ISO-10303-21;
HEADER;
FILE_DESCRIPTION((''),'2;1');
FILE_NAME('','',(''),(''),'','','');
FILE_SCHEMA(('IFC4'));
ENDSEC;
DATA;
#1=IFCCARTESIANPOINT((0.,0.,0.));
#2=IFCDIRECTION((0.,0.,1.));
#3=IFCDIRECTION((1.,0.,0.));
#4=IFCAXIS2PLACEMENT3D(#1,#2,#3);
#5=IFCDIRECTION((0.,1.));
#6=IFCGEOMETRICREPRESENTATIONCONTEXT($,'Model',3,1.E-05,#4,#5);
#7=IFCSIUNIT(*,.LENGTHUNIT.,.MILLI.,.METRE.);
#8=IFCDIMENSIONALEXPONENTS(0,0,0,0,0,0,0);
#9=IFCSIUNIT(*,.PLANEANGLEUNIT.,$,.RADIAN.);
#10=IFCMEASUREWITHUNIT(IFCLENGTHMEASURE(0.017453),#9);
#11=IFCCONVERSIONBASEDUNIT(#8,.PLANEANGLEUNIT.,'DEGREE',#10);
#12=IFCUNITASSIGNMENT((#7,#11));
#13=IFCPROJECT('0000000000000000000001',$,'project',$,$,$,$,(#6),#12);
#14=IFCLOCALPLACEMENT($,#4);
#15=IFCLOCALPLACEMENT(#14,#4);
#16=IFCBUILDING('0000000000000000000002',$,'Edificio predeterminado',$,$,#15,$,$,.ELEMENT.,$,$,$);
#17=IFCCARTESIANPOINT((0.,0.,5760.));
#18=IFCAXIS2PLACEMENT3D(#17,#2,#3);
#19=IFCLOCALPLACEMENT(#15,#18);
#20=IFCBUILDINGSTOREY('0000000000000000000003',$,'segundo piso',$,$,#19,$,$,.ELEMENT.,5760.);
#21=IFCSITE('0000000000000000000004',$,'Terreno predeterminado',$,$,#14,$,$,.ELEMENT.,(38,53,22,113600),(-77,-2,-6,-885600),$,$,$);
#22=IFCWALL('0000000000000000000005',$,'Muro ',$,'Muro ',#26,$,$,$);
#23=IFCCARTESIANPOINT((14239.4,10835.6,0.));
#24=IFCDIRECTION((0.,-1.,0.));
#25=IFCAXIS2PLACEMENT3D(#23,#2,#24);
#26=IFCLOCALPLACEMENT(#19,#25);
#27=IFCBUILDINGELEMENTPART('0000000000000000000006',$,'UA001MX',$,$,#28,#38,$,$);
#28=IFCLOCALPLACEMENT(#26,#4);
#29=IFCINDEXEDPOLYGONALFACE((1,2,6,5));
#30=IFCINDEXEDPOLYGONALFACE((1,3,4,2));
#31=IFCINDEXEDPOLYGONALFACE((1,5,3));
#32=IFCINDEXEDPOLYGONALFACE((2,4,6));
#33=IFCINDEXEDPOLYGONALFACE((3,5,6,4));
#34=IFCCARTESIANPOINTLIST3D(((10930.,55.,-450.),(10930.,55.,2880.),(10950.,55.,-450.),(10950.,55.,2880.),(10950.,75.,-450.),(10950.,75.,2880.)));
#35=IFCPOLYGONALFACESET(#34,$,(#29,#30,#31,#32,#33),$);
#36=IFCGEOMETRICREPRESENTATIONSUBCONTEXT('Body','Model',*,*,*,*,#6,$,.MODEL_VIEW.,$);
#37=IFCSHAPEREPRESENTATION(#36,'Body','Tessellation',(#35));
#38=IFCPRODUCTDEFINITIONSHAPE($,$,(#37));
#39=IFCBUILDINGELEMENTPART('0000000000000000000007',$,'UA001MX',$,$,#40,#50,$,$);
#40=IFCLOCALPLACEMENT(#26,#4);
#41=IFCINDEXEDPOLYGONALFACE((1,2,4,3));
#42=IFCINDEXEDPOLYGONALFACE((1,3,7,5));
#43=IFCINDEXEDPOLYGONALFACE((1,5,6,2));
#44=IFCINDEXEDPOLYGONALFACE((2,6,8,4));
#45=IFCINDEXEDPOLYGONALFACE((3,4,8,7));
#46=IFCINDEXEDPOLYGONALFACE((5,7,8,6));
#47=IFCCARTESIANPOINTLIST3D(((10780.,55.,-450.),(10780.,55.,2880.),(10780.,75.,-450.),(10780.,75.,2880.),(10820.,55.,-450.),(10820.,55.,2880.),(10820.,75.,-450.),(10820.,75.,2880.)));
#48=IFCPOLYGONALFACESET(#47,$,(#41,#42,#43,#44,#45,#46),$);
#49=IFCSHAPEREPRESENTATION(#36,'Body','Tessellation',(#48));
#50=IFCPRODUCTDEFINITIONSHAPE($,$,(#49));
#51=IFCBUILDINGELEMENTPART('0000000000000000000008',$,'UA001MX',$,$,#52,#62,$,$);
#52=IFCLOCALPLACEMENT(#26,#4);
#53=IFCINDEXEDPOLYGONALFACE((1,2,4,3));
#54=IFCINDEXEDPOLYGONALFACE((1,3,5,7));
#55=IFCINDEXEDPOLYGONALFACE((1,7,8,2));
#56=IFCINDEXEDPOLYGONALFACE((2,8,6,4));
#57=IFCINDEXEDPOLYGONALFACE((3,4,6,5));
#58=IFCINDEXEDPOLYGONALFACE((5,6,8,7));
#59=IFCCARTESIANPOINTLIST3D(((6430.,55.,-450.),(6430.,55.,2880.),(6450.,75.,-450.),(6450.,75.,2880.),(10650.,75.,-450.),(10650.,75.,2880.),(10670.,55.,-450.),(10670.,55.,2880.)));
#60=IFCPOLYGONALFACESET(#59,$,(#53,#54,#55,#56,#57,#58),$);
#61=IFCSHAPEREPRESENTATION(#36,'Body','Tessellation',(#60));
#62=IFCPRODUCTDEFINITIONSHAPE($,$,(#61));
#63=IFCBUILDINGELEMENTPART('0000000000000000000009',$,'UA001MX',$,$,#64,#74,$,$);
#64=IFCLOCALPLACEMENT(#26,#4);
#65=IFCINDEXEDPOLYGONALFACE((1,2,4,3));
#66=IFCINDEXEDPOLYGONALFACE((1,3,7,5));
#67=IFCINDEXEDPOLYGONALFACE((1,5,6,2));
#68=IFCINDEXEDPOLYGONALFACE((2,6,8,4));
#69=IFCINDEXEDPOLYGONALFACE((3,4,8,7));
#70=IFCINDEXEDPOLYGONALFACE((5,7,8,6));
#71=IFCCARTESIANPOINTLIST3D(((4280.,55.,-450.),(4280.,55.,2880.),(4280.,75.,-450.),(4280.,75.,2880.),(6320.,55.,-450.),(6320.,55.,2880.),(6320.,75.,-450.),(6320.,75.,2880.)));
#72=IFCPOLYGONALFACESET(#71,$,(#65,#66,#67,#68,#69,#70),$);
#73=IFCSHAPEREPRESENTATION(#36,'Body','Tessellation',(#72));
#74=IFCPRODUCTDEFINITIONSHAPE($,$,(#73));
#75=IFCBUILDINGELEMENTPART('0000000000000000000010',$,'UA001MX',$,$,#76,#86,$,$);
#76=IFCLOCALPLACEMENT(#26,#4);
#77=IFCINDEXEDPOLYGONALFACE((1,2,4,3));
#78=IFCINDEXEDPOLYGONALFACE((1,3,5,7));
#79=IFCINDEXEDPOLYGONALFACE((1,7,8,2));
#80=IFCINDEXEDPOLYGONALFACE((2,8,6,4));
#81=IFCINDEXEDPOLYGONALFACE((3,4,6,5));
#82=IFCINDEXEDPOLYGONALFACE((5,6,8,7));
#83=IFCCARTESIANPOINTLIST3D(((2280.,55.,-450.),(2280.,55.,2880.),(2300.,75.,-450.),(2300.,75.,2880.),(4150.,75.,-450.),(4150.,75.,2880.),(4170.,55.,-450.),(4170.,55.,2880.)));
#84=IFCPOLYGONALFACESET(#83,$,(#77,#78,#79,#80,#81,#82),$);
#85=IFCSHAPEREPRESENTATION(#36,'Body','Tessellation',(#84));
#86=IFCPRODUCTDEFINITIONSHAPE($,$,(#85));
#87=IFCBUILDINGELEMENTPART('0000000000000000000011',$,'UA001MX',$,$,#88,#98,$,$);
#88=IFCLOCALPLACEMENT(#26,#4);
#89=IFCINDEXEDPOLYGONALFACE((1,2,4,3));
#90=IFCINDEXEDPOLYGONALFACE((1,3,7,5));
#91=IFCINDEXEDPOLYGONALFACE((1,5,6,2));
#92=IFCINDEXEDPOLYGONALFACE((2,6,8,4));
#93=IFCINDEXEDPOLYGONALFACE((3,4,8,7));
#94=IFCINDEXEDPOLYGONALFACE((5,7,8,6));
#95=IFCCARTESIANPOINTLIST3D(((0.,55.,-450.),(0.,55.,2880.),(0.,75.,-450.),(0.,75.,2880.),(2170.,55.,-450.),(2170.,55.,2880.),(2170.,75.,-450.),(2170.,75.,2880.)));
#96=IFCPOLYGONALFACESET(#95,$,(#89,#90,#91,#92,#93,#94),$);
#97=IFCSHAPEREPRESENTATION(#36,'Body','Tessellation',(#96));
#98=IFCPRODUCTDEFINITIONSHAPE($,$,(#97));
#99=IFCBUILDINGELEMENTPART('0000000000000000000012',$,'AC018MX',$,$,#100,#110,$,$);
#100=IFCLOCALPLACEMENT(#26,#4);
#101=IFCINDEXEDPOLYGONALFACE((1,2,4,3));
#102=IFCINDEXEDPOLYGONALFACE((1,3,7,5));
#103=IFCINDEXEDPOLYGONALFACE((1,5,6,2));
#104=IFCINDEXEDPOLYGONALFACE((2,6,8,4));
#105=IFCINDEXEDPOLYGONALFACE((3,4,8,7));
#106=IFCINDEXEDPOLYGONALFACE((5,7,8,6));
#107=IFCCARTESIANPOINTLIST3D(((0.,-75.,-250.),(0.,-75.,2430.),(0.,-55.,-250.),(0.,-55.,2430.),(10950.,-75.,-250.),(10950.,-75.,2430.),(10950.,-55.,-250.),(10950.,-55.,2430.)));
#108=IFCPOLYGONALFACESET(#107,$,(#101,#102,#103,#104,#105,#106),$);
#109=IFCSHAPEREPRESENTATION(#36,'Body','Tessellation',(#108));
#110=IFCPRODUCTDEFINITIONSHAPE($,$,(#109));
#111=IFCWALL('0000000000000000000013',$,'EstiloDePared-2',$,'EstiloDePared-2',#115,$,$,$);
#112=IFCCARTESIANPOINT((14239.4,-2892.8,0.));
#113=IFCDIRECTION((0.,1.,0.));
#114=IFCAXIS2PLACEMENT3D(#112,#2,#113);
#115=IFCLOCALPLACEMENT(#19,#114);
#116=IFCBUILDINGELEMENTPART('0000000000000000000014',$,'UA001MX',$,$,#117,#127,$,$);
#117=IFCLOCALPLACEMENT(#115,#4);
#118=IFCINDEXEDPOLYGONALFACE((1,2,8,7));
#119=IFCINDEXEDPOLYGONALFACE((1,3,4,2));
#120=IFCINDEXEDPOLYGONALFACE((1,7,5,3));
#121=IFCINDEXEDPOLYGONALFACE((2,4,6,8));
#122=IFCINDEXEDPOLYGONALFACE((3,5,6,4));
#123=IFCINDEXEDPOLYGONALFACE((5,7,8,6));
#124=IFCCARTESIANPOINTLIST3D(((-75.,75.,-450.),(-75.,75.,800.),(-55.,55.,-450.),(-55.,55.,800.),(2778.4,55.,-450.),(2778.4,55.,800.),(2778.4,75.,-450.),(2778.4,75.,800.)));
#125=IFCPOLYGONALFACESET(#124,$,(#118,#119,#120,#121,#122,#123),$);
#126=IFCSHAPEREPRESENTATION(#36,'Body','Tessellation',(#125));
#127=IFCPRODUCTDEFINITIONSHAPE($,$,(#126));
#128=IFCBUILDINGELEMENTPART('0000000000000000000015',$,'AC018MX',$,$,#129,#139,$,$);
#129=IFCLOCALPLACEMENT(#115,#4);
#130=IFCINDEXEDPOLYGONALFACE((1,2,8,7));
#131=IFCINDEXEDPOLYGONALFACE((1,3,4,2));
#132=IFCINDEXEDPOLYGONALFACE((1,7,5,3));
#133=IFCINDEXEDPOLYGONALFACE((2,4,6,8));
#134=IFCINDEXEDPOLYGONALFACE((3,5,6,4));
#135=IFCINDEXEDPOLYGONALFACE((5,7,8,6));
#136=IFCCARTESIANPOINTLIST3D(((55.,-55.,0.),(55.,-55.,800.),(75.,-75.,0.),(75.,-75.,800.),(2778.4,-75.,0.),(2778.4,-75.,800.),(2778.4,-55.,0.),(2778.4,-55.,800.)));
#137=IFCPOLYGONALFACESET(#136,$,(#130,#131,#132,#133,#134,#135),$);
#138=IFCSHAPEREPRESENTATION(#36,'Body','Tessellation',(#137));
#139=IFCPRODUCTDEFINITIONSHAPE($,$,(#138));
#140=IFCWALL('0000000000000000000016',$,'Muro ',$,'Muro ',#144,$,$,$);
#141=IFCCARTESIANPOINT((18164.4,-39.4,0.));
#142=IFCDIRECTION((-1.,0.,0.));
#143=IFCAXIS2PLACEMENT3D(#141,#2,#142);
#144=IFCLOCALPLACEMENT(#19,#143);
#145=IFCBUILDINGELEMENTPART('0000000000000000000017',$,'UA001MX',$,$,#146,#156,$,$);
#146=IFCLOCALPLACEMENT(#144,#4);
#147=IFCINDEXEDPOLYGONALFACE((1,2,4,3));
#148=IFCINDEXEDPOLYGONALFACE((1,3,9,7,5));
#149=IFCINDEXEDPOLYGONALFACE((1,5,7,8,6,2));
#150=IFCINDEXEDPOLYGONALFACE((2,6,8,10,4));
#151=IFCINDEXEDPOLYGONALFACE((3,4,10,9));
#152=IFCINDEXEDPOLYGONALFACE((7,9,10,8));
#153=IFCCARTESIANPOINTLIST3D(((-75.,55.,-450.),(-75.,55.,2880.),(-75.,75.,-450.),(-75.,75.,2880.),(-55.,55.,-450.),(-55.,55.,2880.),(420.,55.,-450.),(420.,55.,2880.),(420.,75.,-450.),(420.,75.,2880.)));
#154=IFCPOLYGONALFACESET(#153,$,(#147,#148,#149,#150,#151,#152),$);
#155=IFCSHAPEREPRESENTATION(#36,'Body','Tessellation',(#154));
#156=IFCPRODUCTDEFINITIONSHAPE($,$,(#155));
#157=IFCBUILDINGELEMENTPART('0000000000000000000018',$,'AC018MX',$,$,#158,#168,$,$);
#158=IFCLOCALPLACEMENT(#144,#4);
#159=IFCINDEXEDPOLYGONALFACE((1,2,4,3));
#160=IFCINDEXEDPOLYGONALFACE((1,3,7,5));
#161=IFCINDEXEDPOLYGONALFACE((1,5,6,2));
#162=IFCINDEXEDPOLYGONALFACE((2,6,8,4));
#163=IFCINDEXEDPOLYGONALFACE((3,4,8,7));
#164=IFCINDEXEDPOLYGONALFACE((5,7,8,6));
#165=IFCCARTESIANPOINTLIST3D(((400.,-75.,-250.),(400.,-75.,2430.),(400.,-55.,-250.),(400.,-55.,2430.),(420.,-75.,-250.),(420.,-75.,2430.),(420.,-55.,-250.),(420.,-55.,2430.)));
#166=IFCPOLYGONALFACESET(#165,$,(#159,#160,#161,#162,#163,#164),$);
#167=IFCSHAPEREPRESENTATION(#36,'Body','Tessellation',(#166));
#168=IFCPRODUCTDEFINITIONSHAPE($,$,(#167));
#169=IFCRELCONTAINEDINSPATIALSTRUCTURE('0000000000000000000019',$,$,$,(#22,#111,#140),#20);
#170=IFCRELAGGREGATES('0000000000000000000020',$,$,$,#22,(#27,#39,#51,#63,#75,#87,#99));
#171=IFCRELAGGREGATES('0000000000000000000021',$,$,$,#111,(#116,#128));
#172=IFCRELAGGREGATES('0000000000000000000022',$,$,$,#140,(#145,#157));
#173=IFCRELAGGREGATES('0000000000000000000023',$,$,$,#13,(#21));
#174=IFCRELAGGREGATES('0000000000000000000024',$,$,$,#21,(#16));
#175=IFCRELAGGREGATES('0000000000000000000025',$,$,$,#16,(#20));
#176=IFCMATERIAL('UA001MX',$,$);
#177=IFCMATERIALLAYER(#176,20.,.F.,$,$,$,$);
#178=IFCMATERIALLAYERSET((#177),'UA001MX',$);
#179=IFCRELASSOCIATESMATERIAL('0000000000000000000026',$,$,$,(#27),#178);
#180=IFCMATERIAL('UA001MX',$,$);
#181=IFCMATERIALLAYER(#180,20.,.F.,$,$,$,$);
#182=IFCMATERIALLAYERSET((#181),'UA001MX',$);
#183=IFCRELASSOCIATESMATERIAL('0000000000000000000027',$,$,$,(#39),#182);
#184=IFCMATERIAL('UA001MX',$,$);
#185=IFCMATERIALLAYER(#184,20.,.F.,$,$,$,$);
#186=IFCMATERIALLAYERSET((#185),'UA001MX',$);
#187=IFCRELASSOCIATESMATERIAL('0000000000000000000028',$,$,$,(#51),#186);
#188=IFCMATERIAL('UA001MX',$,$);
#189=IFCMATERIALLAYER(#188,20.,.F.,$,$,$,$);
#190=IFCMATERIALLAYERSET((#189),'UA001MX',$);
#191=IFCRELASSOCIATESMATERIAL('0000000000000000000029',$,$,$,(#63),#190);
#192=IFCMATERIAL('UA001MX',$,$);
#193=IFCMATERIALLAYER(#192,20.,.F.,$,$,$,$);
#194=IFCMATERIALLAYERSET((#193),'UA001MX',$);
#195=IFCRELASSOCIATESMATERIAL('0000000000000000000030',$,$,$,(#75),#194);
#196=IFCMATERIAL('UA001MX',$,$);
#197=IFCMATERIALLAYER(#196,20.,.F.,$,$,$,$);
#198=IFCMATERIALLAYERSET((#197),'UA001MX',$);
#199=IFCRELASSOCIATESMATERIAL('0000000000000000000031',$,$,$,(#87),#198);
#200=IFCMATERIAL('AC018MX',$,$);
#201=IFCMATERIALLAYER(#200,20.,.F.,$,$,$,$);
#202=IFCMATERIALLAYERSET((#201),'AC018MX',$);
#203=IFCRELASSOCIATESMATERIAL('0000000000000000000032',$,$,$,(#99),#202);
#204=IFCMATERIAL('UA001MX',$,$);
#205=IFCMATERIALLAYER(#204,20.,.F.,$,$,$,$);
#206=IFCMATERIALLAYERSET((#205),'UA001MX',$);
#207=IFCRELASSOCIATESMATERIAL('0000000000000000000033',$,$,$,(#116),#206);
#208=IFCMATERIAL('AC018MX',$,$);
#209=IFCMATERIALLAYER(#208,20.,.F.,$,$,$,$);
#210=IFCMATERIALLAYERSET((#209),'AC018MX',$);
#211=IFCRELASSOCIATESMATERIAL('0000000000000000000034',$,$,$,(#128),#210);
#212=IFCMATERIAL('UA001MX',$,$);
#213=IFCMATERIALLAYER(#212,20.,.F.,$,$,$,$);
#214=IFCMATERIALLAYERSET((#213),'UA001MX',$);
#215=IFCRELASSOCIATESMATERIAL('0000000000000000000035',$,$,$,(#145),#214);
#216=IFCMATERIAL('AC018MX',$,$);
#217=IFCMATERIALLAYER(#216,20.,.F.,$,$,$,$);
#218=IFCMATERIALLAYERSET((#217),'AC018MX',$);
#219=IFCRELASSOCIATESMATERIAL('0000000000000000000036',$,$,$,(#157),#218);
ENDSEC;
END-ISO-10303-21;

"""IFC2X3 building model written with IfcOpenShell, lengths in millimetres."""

from ifc_helpers import new_model, entity, si_unit, converted_unit, direction, frame, origin_with_axes, place, context, subcontext, project, spatial, polyline, outline, extrude, material, layer, layer_set, layer_usage, element, aggregate, save


model = new_model("IFC2X3")

# Units and contexts
model_context = context("Model", 3, precision=1e-05, world=origin_with_axes(), true_north=direction((0.0, 1.0)))
body_context = subcontext(model_context, "Body", "Model", "MODEL_VIEW")
ifc_project = project(units=[si_unit("LENGTHUNIT", "METRE", prefix="MILLI"), converted_unit("PLANEANGLEUNIT", "DEGREE", entity("IfcLengthMeasure", 0.017453), si_unit("PLANEANGLEUNIT", "RADIAN"), dimensions=[0, 0, 0, 0, 0, 0, 0])], contexts=[model_context])

# Site, building, storey
site_placement = place(None, origin_with_axes())
site = spatial("IfcSite", under=ifc_project, at=site_placement, Name="Terreno predeterminado", CompositionType="ELEMENT", RefLatitude=(38, 53, 22, 113600), RefLongitude=(-77, -2, -6, -885600))
building_placement = place(site_placement, origin_with_axes())
building = spatial("IfcBuilding", under=site, at=building_placement, Name="Edificio predeterminado", CompositionType="ELEMENT")
storey_placement = place(building_placement, frame((0.0, 0.0, 5760.0), z_axis=(0.0, 0.0, 1.0), x_axis=(1.0, 0.0, 0.0)))
storey = spatial("IfcBuildingStorey", under=building, at=storey_placement, Name="segundo piso", CompositionType="ELEMENT", Elevation=5760.0)

# Walls, building element parts
wall_1_placement = place(storey_placement, frame((14239.4, 10835.6, 0.0), z_axis=(0.0, 0.0, 1.0), x_axis=(0.0, -1.0, 0.0)))
wall_1 = element("IfcWall", 1, at=wall_1_placement, inside=storey, Name="Muro ", ObjectType="Muro ")
ifc_material_1 = material(Name="UA001MX")
ifc_layer_1 = layer(ifc_material_1, 20.0, ventilated=False)
ifc_layer_set_1 = layer_set([ifc_layer_1], Name="UA001MX")
ifc_layer_usage_1 = layer_usage(ifc_layer_set_1, "AXIS2", "NEGATIVE", -75.0)
building_element_part_1_placement = place(wall_1_placement, origin_with_axes())
building_element_part_1 = element("IfcBuildingElementPart", 2, at=building_element_part_1_placement, material=ifc_layer_usage_1, Name="UA001MX", context=body_context, shape_type="SweptSolid", body=[
    extrude(outline(polyline([(10950.0, 75.0), (10950.0, 55.0), (10930.0, 55.0), (10950.0, 75.0)])), frame((0.0, 0.0, -450.0), z_axis=(0.0, 0.0, 1.0), x_axis=(1.0, 0.0, 0.0)), (0.0, 0.0, 1.0), 3330.0),
])
ifc_material_2 = material(Name="UA001MX")
ifc_layer_2 = layer(ifc_material_2, 20.0, ventilated=False)
ifc_layer_set_2 = layer_set([ifc_layer_2], Name="UA001MX")
ifc_layer_usage_2 = layer_usage(ifc_layer_set_2, "AXIS2", "NEGATIVE", -75.0)
building_element_part_2_placement = place(wall_1_placement, origin_with_axes())
building_element_part_2 = element("IfcBuildingElementPart", 3, at=building_element_part_2_placement, material=ifc_layer_usage_2, Name="UA001MX", context=body_context, shape_type="SweptSolid", body=[
    extrude(outline(polyline([(10820.0, 75.0), (10820.0, 55.0), (10780.0, 55.0), (10780.0, 75.0), (10820.0, 75.0)])), frame((0.0, 0.0, -450.0), z_axis=(0.0, 0.0, 1.0), x_axis=(1.0, 0.0, 0.0)), (0.0, 0.0, 1.0), 3330.0),
])
ifc_material_3 = material(Name="UA001MX")
ifc_layer_3 = layer(ifc_material_3, 20.0, ventilated=False)
ifc_layer_set_3 = layer_set([ifc_layer_3], Name="UA001MX")
ifc_layer_usage_3 = layer_usage(ifc_layer_set_3, "AXIS2", "NEGATIVE", -75.0)
building_element_part_3_placement = place(wall_1_placement, origin_with_axes())
building_element_part_3 = element("IfcBuildingElementPart", 4, at=building_element_part_3_placement, material=ifc_layer_usage_3, Name="UA001MX", context=body_context, shape_type="SweptSolid", body=[
    extrude(outline(polyline([(10650.0, 75.0), (10670.0, 55.0), (6430.0, 55.0), (6450.0, 75.0), (10650.0, 75.0)])), frame((0.0, 0.0, -450.0), z_axis=(0.0, 0.0, 1.0), x_axis=(1.0, 0.0, 0.0)), (0.0, 0.0, 1.0), 3330.0),
])
ifc_material_4 = material(Name="UA001MX")
ifc_layer_4 = layer(ifc_material_4, 20.0, ventilated=False)
ifc_layer_set_4 = layer_set([ifc_layer_4], Name="UA001MX")
ifc_layer_usage_4 = layer_usage(ifc_layer_set_4, "AXIS2", "NEGATIVE", -75.0)
building_element_part_4_placement = place(wall_1_placement, origin_with_axes())
building_element_part_4 = element("IfcBuildingElementPart", 5, at=building_element_part_4_placement, material=ifc_layer_usage_4, Name="UA001MX", context=body_context, shape_type="SweptSolid", body=[
    extrude(outline(polyline([(4280.0, 75.0), (6320.0, 75.0), (6320.0, 55.0), (4280.0, 55.0), (4280.0, 75.0)])), frame((0.0, 0.0, -450.0), z_axis=(0.0, 0.0, 1.0), x_axis=(1.0, 0.0, 0.0)), (0.0, 0.0, 1.0), 3330.0),
])
ifc_material_5 = material(Name="UA001MX")
ifc_layer_5 = layer(ifc_material_5, 20.0, ventilated=False)
ifc_layer_set_5 = layer_set([ifc_layer_5], Name="UA001MX")
ifc_layer_usage_5 = layer_usage(ifc_layer_set_5, "AXIS2", "NEGATIVE", -75.0)
building_element_part_5_placement = place(wall_1_placement, origin_with_axes())
building_element_part_5 = element("IfcBuildingElementPart", 6, at=building_element_part_5_placement, material=ifc_layer_usage_5, Name="UA001MX", context=body_context, shape_type="SweptSolid", body=[
    extrude(outline(polyline([(4150.0, 75.0), (4170.0, 55.0), (2280.0, 55.0), (2300.0, 75.0), (4150.0, 75.0)])), frame((0.0, 0.0, -450.0), z_axis=(0.0, 0.0, 1.0), x_axis=(1.0, 0.0, 0.0)), (0.0, 0.0, 1.0), 3330.0),
])
ifc_material_6 = material(Name="UA001MX")
ifc_layer_6 = layer(ifc_material_6, 20.0, ventilated=False)
ifc_layer_set_6 = layer_set([ifc_layer_6], Name="UA001MX")
ifc_layer_usage_6 = layer_usage(ifc_layer_set_6, "AXIS2", "NEGATIVE", -75.0)
building_element_part_6_placement = place(wall_1_placement, origin_with_axes())
building_element_part_6 = element("IfcBuildingElementPart", 7, at=building_element_part_6_placement, material=ifc_layer_usage_6, Name="UA001MX", context=body_context, shape_type="SweptSolid", body=[
    extrude(outline(polyline([(2170.0, 75.0), (2170.0, 55.0), (0.0, 55.0), (0.0, 75.0), (2170.0, 75.0)])), frame((0.0, 0.0, -450.0), z_axis=(0.0, 0.0, 1.0), x_axis=(1.0, 0.0, 0.0)), (0.0, 0.0, 1.0), 3330.0),
])
ifc_material_7 = material(Name="AC018MX")
ifc_layer_7 = layer(ifc_material_7, 20.0, ventilated=False)
ifc_layer_set_7 = layer_set([ifc_layer_7], Name="AC018MX")
ifc_layer_usage_7 = layer_usage(ifc_layer_set_7, "AXIS2", "NEGATIVE", 55.0)
building_element_part_7_placement = place(wall_1_placement, origin_with_axes())
building_element_part_7 = element("IfcBuildingElementPart", 8, at=building_element_part_7_placement, material=ifc_layer_usage_7, Name="AC018MX", context=body_context, shape_type="SweptSolid", body=[
    extrude(outline(polyline([(10950.0, -55.0), (10950.0, -75.0), (0.0, -75.0), (0.0, -55.0), (10950.0, -55.0)])), frame((0.0, 0.0, -250.0), z_axis=(0.0, 0.0, 1.0), x_axis=(1.0, 0.0, 0.0)), (0.0, 0.0, 1.0), 2680.0),
])
aggregate(wall_1, [building_element_part_1, building_element_part_2, building_element_part_3, building_element_part_4, building_element_part_5, building_element_part_6, building_element_part_7])
wall_2_placement = place(storey_placement, frame((14239.4, -2892.8, 0.0), z_axis=(0.0, 0.0, 1.0), x_axis=(0.0, 1.0, 0.0)))
wall_2 = element("IfcWall", 9, at=wall_2_placement, inside=storey, Name="EstiloDePared-2", ObjectType="EstiloDePared-2")
ifc_material_8 = material(Name="UA001MX")
ifc_layer_8 = layer(ifc_material_8, 20.0, ventilated=False)
ifc_layer_set_8 = layer_set([ifc_layer_8], Name="UA001MX")
ifc_layer_usage_8 = layer_usage(ifc_layer_set_8, "AXIS2", "NEGATIVE", -75.0)
building_element_part_8_placement = place(wall_2_placement, origin_with_axes())
building_element_part_8 = element("IfcBuildingElementPart", 10, at=building_element_part_8_placement, material=ifc_layer_usage_8, Name="UA001MX", context=body_context, shape_type="SweptSolid", body=[
    extrude(outline(polyline([(2778.4, 75.0), (2778.4, 55.0), (-55.0, 55.0), (-75.0, 75.0), (2778.4, 75.0)])), frame((0.0, 0.0, -450.0), z_axis=(0.0, 0.0, 1.0), x_axis=(1.0, 0.0, 0.0)), (0.0, 0.0, 1.0), 1250.0),
])
ifc_material_9 = material(Name="AC018MX")
ifc_layer_9 = layer(ifc_material_9, 20.0, ventilated=False)
ifc_layer_set_9 = layer_set([ifc_layer_9], Name="AC018MX")
ifc_layer_usage_9 = layer_usage(ifc_layer_set_9, "AXIS2", "NEGATIVE", 55.0)
building_element_part_9_placement = place(wall_2_placement, origin_with_axes())
building_element_part_9 = element("IfcBuildingElementPart", 11, at=building_element_part_9_placement, material=ifc_layer_usage_9, Name="AC018MX", context=body_context, shape_type="SweptSolid", body=[
    extrude(outline(polyline([(2778.4, -55.0), (2778.4, -75.0), (75.0, -75.0), (55.0, -55.0), (2778.4, -55.0)])), origin_with_axes(), (0.0, 0.0, 1.0), 800.0),
])
aggregate(wall_2, [building_element_part_8, building_element_part_9])
wall_3_placement = place(storey_placement, frame((18164.4, -39.4, 0.0), z_axis=(0.0, 0.0, 1.0), x_axis=(-1.0, 0.0, 0.0)))
wall_3 = element("IfcWall", 12, at=wall_3_placement, inside=storey, Name="Muro ", ObjectType="Muro ")
ifc_material_10 = material(Name="UA001MX")
ifc_layer_10 = layer(ifc_material_10, 20.0, ventilated=False)
ifc_layer_set_10 = layer_set([ifc_layer_10], Name="UA001MX")
ifc_layer_usage_10 = layer_usage(ifc_layer_set_10, "AXIS2", "NEGATIVE", -75.0)
building_element_part_10_placement = place(wall_3_placement, origin_with_axes())
building_element_part_10 = element("IfcBuildingElementPart", 13, at=building_element_part_10_placement, material=ifc_layer_usage_10, Name="UA001MX", context=body_context, shape_type="SweptSolid", body=[
    extrude(outline(polyline([(420.0, 75.0), (420.0, 55.0), (-55.0, 55.0), (-75.0, 55.0), (-75.0, 75.0), (420.0, 75.0)])), frame((0.0, 0.0, -450.0), z_axis=(0.0, 0.0, 1.0), x_axis=(1.0, 0.0, 0.0)), (0.0, 0.0, 1.0), 3330.0),
])
ifc_material_11 = material(Name="AC018MX")
ifc_layer_11 = layer(ifc_material_11, 20.0, ventilated=False)
ifc_layer_set_11 = layer_set([ifc_layer_11], Name="AC018MX")
ifc_layer_usage_11 = layer_usage(ifc_layer_set_11, "AXIS2", "NEGATIVE", 55.0)
building_element_part_11_placement = place(wall_3_placement, origin_with_axes())
building_element_part_11 = element("IfcBuildingElementPart", 14, at=building_element_part_11_placement, material=ifc_layer_usage_11, Name="AC018MX", context=body_context, shape_type="SweptSolid", body=[
    extrude(outline(polyline([(420.0, -55.0), (420.0, -75.0), (400.0, -75.0), (400.0, -55.0), (420.0, -55.0)])), frame((0.0, 0.0, -250.0), z_axis=(0.0, 0.0, 1.0), x_axis=(1.0, 0.0, 0.0)), (0.0, 0.0, 1.0), 2680.0),
])
aggregate(wall_3, [building_element_part_10, building_element_part_11])

save(model, "model.ifc")
